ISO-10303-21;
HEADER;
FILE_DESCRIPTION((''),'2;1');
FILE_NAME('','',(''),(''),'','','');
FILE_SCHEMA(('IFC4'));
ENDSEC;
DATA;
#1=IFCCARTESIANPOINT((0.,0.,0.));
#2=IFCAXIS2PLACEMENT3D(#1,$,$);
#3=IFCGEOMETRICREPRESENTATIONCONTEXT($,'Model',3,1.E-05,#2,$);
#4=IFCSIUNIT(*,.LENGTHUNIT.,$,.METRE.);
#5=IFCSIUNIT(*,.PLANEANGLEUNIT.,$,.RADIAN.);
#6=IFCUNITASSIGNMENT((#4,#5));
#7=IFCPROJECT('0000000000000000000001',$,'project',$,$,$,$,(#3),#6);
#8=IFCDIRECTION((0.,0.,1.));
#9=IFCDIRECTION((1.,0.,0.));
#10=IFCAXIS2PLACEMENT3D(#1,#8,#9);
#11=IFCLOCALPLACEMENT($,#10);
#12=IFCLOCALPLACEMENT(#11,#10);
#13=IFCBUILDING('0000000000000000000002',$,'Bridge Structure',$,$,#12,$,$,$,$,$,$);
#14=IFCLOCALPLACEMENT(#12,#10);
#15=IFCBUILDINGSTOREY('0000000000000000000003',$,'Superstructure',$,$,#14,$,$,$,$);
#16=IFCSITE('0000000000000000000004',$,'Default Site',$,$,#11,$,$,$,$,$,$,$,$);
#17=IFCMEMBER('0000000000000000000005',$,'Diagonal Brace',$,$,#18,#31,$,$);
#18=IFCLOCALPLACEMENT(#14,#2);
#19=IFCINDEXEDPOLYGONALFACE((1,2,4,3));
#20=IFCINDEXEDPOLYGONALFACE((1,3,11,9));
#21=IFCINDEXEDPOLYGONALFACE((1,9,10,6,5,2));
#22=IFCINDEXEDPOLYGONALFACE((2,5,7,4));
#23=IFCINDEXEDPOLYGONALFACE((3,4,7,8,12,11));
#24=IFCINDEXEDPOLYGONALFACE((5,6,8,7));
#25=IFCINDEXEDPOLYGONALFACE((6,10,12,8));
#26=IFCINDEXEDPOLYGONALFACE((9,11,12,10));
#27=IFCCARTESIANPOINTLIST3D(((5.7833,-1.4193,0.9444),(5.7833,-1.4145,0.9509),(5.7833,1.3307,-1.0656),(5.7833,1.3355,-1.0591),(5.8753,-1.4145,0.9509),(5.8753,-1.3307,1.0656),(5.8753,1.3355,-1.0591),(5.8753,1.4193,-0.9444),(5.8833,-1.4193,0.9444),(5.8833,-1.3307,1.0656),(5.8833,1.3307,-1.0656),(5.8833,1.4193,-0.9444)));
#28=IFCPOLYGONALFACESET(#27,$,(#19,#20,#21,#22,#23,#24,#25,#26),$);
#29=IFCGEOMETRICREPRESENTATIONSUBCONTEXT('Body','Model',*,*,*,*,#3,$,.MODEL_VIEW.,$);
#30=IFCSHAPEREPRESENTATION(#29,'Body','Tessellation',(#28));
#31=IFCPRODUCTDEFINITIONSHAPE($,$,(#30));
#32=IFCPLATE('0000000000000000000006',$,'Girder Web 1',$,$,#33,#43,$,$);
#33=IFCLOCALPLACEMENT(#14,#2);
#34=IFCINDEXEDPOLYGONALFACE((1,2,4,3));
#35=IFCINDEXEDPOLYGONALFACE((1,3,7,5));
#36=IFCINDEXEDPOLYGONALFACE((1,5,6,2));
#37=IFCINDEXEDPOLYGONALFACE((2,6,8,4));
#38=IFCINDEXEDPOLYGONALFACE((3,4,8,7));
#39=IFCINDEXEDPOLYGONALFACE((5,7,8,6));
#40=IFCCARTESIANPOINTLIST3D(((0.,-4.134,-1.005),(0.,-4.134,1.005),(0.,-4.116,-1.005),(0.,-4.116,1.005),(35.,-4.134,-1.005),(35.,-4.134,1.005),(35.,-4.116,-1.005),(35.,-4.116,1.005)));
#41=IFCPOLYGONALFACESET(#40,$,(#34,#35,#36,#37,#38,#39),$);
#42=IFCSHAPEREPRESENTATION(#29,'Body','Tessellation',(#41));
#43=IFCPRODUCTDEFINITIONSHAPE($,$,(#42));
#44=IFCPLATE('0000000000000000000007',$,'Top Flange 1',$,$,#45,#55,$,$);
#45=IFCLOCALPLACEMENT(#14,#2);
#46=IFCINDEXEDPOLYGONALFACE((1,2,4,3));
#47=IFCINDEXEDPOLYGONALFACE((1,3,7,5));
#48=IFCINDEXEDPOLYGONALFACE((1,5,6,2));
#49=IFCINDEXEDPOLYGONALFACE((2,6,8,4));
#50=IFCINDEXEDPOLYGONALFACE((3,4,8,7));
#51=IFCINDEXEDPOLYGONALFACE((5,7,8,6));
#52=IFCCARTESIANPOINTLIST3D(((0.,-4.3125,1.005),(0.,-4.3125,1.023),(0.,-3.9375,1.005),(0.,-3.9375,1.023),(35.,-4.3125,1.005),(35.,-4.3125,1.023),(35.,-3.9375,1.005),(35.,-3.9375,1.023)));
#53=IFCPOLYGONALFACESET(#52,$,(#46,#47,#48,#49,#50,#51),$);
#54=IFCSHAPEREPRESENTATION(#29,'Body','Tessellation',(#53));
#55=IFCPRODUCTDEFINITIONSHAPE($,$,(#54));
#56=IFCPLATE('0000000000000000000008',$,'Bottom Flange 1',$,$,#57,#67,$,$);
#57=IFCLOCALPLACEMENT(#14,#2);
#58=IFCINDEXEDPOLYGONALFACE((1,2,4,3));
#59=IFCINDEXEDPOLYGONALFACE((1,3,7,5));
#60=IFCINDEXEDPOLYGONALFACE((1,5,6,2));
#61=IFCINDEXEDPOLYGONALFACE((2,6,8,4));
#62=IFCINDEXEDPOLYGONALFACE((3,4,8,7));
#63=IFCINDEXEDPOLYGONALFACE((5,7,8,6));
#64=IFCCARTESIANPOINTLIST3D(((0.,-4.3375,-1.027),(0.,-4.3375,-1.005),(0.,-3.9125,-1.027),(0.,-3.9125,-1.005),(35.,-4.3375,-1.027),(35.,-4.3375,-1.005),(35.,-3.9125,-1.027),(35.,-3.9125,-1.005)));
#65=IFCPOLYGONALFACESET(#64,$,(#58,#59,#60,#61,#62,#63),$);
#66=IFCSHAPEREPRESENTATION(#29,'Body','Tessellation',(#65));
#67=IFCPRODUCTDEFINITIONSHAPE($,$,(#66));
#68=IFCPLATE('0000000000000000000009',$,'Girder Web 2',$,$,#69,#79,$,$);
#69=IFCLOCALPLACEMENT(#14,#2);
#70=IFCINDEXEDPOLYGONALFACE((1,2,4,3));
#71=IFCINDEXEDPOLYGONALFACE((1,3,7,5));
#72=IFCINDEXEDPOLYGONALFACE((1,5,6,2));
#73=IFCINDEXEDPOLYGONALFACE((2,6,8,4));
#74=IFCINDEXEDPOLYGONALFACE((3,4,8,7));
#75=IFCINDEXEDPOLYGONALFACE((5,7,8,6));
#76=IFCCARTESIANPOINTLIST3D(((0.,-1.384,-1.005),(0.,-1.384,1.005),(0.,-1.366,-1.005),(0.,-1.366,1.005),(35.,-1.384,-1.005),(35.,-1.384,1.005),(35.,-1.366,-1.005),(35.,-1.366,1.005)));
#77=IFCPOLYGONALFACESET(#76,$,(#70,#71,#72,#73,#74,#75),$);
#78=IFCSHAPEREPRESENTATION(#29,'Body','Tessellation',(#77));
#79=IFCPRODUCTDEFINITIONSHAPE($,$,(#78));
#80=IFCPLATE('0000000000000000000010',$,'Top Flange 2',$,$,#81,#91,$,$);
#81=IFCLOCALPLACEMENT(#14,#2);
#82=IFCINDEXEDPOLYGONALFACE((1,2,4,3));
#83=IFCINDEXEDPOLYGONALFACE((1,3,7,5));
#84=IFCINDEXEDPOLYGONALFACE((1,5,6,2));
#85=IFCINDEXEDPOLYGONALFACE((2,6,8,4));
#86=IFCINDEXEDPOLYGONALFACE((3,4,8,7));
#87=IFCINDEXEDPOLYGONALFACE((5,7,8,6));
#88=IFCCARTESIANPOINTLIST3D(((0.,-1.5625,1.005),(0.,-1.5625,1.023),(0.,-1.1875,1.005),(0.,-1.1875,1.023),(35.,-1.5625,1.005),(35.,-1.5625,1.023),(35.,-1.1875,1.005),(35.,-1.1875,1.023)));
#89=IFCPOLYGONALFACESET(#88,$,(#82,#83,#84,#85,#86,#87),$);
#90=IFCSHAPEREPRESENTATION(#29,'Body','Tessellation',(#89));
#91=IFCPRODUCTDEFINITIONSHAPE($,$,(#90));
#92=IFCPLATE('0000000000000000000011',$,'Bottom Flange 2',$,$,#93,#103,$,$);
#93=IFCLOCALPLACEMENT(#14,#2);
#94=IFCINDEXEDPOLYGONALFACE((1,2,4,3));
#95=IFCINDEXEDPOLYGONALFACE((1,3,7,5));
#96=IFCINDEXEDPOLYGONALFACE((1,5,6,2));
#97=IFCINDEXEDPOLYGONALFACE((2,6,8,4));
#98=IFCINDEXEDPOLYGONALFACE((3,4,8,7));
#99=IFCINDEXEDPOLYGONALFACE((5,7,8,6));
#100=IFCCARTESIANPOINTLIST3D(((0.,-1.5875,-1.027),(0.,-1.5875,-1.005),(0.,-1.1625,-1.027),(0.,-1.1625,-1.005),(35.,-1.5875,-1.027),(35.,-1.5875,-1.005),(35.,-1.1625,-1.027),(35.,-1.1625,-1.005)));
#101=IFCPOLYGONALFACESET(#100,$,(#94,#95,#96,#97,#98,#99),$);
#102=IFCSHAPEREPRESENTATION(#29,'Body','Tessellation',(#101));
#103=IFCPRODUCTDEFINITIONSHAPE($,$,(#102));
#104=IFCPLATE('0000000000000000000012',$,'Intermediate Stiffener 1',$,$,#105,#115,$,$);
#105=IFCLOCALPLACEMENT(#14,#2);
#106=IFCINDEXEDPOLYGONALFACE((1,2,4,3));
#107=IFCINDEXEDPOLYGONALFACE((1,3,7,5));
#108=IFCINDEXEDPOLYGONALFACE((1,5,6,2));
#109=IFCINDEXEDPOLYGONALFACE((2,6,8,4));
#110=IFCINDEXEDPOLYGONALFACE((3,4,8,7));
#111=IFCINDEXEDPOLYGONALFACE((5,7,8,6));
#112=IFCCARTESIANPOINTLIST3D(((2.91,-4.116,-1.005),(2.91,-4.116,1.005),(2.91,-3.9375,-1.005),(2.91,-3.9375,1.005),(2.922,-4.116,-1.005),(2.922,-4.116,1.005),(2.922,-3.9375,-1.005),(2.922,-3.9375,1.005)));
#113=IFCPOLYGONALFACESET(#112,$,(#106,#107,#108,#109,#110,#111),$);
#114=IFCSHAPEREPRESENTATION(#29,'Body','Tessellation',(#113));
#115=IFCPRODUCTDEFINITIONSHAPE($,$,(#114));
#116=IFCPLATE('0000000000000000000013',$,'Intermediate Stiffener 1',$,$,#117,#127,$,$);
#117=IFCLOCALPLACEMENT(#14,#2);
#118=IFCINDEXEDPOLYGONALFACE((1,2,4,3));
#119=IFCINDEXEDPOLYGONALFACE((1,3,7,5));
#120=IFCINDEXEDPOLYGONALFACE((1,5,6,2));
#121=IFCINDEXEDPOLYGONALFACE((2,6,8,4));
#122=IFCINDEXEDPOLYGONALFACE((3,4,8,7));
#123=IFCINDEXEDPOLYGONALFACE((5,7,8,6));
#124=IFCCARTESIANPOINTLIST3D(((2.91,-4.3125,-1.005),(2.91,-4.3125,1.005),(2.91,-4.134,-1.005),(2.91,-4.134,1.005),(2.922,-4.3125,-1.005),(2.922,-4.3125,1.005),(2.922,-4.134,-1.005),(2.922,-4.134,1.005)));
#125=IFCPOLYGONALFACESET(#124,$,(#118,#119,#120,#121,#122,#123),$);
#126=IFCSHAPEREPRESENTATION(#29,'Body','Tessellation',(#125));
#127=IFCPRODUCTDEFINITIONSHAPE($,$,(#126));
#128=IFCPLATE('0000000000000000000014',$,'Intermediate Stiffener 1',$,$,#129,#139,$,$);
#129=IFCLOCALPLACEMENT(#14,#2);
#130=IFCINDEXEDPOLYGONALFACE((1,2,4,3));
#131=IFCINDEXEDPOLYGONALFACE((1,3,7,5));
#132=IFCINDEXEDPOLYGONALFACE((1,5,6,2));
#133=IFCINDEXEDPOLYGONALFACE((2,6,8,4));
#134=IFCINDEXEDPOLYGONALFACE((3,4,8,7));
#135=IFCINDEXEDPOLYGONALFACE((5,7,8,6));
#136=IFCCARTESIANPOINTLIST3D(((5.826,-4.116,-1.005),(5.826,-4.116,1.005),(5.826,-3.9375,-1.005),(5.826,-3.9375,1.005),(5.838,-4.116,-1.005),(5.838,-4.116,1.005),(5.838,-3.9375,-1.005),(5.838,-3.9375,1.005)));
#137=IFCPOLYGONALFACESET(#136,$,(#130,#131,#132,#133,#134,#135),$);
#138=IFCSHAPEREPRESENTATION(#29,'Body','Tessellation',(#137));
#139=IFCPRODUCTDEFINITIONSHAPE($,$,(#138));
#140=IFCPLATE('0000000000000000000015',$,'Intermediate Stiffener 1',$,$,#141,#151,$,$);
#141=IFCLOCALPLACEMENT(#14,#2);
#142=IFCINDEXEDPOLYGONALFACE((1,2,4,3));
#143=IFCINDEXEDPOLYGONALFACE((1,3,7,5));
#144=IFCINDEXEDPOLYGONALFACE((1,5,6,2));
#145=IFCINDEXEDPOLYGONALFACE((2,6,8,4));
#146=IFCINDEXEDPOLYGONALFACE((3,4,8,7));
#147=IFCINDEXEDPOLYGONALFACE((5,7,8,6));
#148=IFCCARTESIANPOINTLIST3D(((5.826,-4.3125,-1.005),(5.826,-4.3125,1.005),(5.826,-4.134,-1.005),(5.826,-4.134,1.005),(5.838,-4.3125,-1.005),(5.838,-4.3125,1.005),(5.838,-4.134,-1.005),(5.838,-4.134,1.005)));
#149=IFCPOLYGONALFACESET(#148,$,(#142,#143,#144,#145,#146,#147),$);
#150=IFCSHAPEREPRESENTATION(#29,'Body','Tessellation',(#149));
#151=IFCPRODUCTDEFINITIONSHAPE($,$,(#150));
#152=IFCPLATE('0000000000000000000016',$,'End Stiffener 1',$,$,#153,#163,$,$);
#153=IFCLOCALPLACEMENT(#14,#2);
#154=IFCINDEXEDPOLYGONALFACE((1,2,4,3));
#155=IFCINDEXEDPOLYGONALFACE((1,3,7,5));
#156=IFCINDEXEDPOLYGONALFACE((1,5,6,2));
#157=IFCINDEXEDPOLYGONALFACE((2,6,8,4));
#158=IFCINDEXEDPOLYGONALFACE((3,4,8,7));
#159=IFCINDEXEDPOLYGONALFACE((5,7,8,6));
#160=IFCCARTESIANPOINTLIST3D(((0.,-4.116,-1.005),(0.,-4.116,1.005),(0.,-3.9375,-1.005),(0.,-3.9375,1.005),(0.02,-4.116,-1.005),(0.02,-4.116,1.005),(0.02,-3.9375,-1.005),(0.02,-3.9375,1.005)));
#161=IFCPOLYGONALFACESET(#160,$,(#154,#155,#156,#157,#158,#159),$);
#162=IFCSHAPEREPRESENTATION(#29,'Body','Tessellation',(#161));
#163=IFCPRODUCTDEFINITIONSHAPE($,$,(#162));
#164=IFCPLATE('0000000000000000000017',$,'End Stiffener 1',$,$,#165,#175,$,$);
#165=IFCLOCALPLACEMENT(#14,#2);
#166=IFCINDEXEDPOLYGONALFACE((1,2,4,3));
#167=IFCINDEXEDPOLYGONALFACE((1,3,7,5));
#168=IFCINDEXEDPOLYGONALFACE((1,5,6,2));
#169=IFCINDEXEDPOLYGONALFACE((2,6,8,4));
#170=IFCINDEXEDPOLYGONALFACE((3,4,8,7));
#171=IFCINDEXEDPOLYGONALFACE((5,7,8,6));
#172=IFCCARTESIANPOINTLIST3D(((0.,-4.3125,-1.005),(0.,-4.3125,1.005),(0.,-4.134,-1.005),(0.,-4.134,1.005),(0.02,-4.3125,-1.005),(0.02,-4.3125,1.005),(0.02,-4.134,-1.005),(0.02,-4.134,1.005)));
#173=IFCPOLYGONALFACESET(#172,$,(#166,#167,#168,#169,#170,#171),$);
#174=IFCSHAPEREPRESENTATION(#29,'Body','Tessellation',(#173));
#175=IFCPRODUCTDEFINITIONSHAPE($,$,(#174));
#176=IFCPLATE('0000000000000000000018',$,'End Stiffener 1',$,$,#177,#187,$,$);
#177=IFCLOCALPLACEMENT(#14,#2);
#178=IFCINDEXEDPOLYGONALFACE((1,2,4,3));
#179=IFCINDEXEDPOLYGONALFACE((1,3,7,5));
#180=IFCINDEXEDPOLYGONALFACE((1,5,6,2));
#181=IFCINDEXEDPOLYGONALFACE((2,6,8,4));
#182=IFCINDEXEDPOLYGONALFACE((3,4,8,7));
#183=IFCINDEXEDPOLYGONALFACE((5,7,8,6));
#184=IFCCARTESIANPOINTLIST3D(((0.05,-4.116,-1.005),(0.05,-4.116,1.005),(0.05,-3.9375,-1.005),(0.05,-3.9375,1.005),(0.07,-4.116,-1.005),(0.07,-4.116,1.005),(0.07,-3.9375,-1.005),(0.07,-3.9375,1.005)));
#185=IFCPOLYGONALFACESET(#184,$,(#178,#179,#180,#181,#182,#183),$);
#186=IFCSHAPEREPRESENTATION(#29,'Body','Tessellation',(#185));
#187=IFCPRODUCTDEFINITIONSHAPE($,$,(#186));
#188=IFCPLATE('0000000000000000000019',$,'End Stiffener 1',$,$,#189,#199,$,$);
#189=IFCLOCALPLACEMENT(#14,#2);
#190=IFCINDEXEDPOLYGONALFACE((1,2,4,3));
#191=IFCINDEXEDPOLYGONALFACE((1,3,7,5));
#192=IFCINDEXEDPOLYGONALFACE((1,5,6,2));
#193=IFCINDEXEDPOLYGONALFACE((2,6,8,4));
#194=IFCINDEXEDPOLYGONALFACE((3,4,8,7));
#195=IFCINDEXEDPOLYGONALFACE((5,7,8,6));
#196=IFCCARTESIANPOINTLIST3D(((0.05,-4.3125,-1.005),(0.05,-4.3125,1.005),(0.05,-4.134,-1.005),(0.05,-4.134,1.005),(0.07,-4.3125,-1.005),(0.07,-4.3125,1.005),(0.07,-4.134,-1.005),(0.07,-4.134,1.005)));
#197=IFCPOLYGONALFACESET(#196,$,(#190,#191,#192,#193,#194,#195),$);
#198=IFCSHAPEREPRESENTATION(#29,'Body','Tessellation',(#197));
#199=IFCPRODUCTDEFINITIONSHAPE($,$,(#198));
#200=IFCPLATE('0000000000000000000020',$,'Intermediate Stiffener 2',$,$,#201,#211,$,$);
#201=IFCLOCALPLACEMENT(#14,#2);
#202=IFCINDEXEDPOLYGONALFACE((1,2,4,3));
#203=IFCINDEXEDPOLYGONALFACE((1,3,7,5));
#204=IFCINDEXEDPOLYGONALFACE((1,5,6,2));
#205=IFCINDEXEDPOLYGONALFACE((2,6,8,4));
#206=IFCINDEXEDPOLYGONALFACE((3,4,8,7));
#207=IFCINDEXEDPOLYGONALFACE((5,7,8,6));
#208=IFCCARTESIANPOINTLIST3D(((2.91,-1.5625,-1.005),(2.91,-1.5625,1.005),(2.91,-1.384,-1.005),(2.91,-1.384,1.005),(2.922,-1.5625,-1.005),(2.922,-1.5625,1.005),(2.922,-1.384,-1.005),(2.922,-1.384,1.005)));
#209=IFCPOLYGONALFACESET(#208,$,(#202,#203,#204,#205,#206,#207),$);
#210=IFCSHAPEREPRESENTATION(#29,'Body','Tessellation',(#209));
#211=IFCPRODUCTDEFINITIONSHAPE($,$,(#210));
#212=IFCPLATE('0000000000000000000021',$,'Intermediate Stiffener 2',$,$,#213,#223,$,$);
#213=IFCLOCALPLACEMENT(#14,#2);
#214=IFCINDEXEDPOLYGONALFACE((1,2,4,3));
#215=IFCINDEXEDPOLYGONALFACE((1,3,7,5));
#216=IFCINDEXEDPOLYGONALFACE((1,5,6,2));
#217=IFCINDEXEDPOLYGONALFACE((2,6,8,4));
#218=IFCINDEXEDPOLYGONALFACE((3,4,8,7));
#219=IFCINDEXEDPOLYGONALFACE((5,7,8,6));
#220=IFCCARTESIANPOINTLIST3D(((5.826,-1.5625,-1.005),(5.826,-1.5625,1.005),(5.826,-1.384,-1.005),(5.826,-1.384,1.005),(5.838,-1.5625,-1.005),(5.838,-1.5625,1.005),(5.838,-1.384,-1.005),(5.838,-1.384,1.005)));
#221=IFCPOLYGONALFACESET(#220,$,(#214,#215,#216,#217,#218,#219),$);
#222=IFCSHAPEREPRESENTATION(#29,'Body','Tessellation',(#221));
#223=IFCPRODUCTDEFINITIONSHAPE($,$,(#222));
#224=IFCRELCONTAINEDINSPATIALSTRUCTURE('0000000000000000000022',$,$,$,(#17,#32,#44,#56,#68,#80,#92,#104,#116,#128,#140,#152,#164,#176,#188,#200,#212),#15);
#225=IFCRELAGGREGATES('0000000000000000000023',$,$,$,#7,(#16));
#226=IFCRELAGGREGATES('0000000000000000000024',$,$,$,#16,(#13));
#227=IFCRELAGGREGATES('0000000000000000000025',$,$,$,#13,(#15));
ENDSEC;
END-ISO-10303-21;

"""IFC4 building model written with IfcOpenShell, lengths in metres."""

from ifc_helpers import new_model, si_unit, frame, origin, origin_with_axes, origin_2d_with_axis, place, context, subcontext, project, spatial, rectangle, l_section, extrude, element, save


model = new_model("IFC4")

# Units and contexts
model_context = context("Model", 3, precision=1e-05, world=origin())
body_context = subcontext(model_context, "Body", "Model", "MODEL_VIEW")
ifc_project = project(units=[si_unit("LENGTHUNIT", "METRE"), si_unit("PLANEANGLEUNIT", "RADIAN")], contexts=[model_context])

# Site, building, storey
site_placement = place(None, origin_with_axes())
site = spatial("IfcSite", under=ifc_project, at=site_placement, Name="Default Site")
building_placement = place(site_placement, origin_with_axes())
building = spatial("IfcBuilding", under=site, at=building_placement, Name="Bridge Structure")
storey_placement = place(building_placement, origin_with_axes())
storey = spatial("IfcBuildingStorey", under=building, at=storey_placement, Name="Superstructure")

# Member
member_placement = place(storey_placement, frame((5.8333, -1.375, 1.005), z_axis=(0.0, 0.807337, -0.59009), x_axis=(-1.0, 0.0, 0.0)))
element("IfcMember", 1, at=member_placement, inside=storey, Name="Diagonal Brace", context=body_context, shape_type="SweptSolid", body=[
    extrude(l_section(Depth=0.15, Width=0.1, Thickness=0.008, at=origin_2d_with_axis()), origin_with_axes(), (0.0, 0.0, 1.0), 3.4063),
])

# Plates
plate_1_placement = place(storey_placement, frame((0.0, -4.125, 0.0), z_axis=(1.0, 0.0, 0.0), x_axis=(0.0, 1.0, 0.0)))
element("IfcPlate", 2, at=plate_1_placement, inside=storey, Name="Girder Web 1", context=body_context, shape_type="SweptSolid", body=[
    extrude(rectangle(XDim=0.018, YDim=2.01, at=origin_2d_with_axis()), origin_with_axes(), (0.0, 0.0, 1.0), 35.0),
])
plate_2_placement = place(storey_placement, frame((0.0, -4.125, 1.014), z_axis=(1.0, 0.0, 0.0), x_axis=(0.0, 1.0, 0.0)))
element("IfcPlate", 3, at=plate_2_placement, inside=storey, Name="Top Flange 1", context=body_context, shape_type="SweptSolid", body=[
    extrude(rectangle(XDim=0.375, YDim=0.018, at=origin_2d_with_axis()), origin_with_axes(), (0.0, 0.0, 1.0), 35.0),
])
plate_3_placement = place(storey_placement, frame((0.0, -4.125, -1.016), z_axis=(1.0, 0.0, 0.0), x_axis=(0.0, 1.0, 0.0)))
element("IfcPlate", 4, at=plate_3_placement, inside=storey, Name="Bottom Flange 1", context=body_context, shape_type="SweptSolid", body=[
    extrude(rectangle(XDim=0.425, YDim=0.022, at=origin_2d_with_axis()), origin_with_axes(), (0.0, 0.0, 1.0), 35.0),
])
plate_4_placement = place(storey_placement, frame((0.0, -1.375, 0.0), z_axis=(1.0, 0.0, 0.0), x_axis=(0.0, 1.0, 0.0)))
element("IfcPlate", 5, at=plate_4_placement, inside=storey, Name="Girder Web 2", context=body_context, shape_type="SweptSolid", body=[
    extrude(rectangle(XDim=0.018, YDim=2.01, at=origin_2d_with_axis()), origin_with_axes(), (0.0, 0.0, 1.0), 35.0),
])
plate_5_placement = place(storey_placement, frame((0.0, -1.375, 1.014), z_axis=(1.0, 0.0, 0.0), x_axis=(0.0, 1.0, 0.0)))
element("IfcPlate", 6, at=plate_5_placement, inside=storey, Name="Top Flange 2", context=body_context, shape_type="SweptSolid", body=[
    extrude(rectangle(XDim=0.375, YDim=0.018, at=origin_2d_with_axis()), origin_with_axes(), (0.0, 0.0, 1.0), 35.0),
])
plate_6_placement = place(storey_placement, frame((0.0, -1.375, -1.016), z_axis=(1.0, 0.0, 0.0), x_axis=(0.0, 1.0, 0.0)))
element("IfcPlate", 7, at=plate_6_placement, inside=storey, Name="Bottom Flange 2", context=body_context, shape_type="SweptSolid", body=[
    extrude(rectangle(XDim=0.425, YDim=0.022, at=origin_2d_with_axis()), origin_with_axes(), (0.0, 0.0, 1.0), 35.0),
])
for number, where, z_axis, x_axis, name in (
    (8, (2.916, -4.0267, -1.005), (0.0, 0.0, 1.0), (1.0, 0.0, 0.0), "Intermediate Stiffener 1"),
    (9, (2.916, -4.2233, -1.005), (0.0, 0.0, 1.0), (1.0, 0.0, 0.0), "Intermediate Stiffener 1"),
    (10, (5.832, -4.0267, -1.005), (0.0, 0.0, 1.0), (1.0, 0.0, 0.0), "Intermediate Stiffener 1"),
    (11, (5.832, -4.2233, -1.005), (0.0, 0.0, 1.0), (1.0, 0.0, 0.0), "Intermediate Stiffener 1"),
):
    element("IfcPlate", number, at=place(storey_placement, frame(where, z_axis=z_axis, x_axis=x_axis)), inside=storey, Name=name, context=body_context, shape_type="SweptSolid", body=[
        extrude(rectangle(XDim=0.012, YDim=0.1785, at=origin_2d_with_axis()), origin_with_axes(), (0.0, 0.0, 1.0), 2.01),
    ])
for number, where, z_axis, x_axis, name in (
    (12, (0.01, -4.0267, -1.005), (0.0, 0.0, 1.0), (1.0, 0.0, 0.0), "End Stiffener 1"),
    (13, (0.01, -4.2233, -1.005), (0.0, 0.0, 1.0), (1.0, 0.0, 0.0), "End Stiffener 1"),
    (14, (0.06, -4.0267, -1.005), (0.0, 0.0, 1.0), (1.0, 0.0, 0.0), "End Stiffener 1"),
    (15, (0.06, -4.2233, -1.005), (0.0, 0.0, 1.0), (1.0, 0.0, 0.0), "End Stiffener 1"),
):
    element("IfcPlate", number, at=place(storey_placement, frame(where, z_axis=z_axis, x_axis=x_axis)), inside=storey, Name=name, context=body_context, shape_type="SweptSolid", body=[
        extrude(rectangle(XDim=0.02, YDim=0.1785, at=origin_2d_with_axis()), origin_with_axes(), (0.0, 0.0, 1.0), 2.01),
    ])
for number, where, z_axis, x_axis, name in (
    (16, (2.916, -1.4732, -1.005), (0.0, 0.0, 1.0), (1.0, 0.0, 0.0), "Intermediate Stiffener 2"),
    (17, (5.832, -1.4732, -1.005), (0.0, 0.0, 1.0), (1.0, 0.0, 0.0), "Intermediate Stiffener 2"),
):
    element("IfcPlate", number, at=place(storey_placement, frame(where, z_axis=z_axis, x_axis=x_axis)), inside=storey, Name=name, context=body_context, shape_type="SweptSolid", body=[
        extrude(rectangle(XDim=0.012, YDim=0.1785, at=origin_2d_with_axis()), origin_with_axes(), (0.0, 0.0, 1.0), 2.01),
    ])

save(model, "model.ifc")
